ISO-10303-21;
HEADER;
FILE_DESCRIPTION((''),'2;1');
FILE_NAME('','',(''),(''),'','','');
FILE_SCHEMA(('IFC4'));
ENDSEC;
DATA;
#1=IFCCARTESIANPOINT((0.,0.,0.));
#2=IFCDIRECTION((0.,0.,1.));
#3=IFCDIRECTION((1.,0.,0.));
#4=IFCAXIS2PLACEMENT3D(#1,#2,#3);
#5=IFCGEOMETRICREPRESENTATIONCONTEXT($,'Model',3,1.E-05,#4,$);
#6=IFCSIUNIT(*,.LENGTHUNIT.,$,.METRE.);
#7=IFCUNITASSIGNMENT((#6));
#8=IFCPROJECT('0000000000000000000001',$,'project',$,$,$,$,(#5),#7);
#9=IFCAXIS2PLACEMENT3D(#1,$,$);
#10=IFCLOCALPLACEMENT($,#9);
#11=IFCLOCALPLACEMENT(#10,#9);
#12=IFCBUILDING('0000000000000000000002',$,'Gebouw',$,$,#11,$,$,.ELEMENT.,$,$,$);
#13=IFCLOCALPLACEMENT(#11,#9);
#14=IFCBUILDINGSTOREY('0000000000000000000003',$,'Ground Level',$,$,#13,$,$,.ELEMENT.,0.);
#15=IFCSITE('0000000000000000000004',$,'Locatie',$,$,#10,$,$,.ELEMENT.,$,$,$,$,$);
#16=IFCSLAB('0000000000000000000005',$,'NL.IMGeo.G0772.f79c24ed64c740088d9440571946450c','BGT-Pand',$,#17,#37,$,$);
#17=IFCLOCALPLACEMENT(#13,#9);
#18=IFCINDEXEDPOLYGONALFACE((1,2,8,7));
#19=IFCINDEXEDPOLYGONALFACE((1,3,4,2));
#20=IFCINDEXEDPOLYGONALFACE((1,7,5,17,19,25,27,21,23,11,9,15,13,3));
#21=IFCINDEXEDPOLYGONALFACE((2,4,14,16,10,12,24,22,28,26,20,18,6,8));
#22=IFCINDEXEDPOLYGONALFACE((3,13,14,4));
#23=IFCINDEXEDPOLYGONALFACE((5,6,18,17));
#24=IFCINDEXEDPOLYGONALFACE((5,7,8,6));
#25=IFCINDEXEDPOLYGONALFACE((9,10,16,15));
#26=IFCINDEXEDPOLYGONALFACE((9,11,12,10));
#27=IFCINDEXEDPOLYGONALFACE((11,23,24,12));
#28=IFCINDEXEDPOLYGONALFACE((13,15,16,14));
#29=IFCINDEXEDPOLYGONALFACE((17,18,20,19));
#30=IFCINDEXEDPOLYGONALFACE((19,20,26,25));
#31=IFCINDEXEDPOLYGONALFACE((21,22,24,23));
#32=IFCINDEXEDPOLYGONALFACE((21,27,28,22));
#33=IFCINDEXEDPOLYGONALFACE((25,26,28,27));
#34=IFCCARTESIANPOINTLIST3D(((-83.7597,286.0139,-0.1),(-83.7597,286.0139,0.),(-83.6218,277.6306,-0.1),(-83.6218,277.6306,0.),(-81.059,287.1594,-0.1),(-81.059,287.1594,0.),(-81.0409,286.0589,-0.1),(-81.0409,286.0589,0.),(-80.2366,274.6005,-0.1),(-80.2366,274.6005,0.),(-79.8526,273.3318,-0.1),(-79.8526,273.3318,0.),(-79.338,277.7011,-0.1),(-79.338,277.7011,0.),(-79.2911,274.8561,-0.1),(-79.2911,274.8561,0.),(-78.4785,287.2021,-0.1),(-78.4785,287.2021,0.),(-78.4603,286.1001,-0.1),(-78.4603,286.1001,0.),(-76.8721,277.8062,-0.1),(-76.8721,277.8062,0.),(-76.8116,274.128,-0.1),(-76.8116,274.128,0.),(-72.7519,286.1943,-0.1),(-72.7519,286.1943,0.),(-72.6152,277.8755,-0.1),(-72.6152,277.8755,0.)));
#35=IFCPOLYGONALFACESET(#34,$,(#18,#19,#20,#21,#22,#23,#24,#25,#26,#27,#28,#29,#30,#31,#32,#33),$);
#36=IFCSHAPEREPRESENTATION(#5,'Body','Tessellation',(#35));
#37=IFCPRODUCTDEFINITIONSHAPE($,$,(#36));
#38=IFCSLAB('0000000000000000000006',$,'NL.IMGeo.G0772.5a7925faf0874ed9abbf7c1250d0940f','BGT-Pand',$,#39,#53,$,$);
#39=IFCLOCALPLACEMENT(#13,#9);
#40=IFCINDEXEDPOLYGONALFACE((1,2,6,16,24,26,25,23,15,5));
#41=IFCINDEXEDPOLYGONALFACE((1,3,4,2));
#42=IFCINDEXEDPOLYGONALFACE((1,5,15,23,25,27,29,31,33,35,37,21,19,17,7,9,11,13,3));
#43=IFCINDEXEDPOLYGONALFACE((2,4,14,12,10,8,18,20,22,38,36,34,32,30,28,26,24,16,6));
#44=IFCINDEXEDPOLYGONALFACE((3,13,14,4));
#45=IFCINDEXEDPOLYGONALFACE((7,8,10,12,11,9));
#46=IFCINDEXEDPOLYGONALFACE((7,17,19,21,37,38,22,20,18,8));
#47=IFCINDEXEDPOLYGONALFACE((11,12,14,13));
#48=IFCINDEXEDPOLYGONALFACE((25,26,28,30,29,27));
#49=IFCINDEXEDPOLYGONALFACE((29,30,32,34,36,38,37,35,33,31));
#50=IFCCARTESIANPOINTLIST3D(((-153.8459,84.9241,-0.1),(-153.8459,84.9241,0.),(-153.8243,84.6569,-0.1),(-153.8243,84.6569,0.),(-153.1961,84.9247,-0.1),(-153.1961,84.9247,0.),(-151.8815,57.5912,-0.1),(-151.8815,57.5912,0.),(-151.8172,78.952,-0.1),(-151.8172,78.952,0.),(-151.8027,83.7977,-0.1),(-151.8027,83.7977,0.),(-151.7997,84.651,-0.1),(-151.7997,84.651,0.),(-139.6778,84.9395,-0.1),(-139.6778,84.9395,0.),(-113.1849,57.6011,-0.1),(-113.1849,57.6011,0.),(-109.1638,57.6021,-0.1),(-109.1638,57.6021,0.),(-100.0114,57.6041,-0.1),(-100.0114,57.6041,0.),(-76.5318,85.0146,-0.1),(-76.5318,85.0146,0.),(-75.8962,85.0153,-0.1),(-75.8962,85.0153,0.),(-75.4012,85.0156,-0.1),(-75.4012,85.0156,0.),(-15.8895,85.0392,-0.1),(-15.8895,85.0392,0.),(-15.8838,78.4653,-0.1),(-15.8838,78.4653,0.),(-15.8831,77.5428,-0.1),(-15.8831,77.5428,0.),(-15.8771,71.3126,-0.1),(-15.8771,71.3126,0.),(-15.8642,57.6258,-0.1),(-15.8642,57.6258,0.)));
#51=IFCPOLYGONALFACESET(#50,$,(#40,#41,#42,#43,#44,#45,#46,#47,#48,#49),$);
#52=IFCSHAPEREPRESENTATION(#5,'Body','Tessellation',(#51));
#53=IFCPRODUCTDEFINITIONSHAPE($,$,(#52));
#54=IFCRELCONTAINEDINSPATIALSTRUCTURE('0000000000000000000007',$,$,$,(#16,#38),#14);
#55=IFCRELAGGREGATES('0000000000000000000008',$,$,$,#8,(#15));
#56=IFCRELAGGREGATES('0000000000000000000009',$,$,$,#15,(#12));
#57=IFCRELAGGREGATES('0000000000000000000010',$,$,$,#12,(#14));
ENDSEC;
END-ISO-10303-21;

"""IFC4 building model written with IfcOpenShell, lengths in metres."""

from ifc_helpers import new_model, si_unit, frame, origin, origin_with_axes, place, context, project, spatial, polyline, outline, extrude, element, save


model = new_model("IFC4")

# Units and contexts
model_context = context("Model", 3, precision=1e-05, world=origin_with_axes())
ifc_project = project(units=[si_unit("LENGTHUNIT", "METRE")], contexts=[model_context])

# Site, building, storey
site_placement = place(None, origin())
site = spatial("IfcSite", under=ifc_project, at=site_placement, Name="Locatie", CompositionType="ELEMENT")
building_placement = place(site_placement, origin())
building = spatial("IfcBuilding", under=site, at=building_placement, Name="Gebouw", CompositionType="ELEMENT")
storey_placement = place(building_placement, origin())
storey = spatial("IfcBuildingStorey", under=building, at=storey_placement, Name="Ground Level", CompositionType="ELEMENT", Elevation=0.0)

# Slabs
slab_1_placement = place(storey_placement, origin())
element("IfcSlab", 1, at=slab_1_placement, inside=storey, Name="NL.IMGeo.G0772.f79c24ed64c740088d9440571946450c", Description="BGT-Pand", context=model_context, shape_type="SweptSolid", body=[
    extrude(outline(polyline([(-72.6152, 277.8755), (-76.8721, 277.8062), (-76.8116, 274.128), (-79.8526, 273.3318), (-80.2366, 274.6005), (-79.2911, 274.8561), (-79.338, 277.7011), (-83.6218, 277.6306), (-83.7597, 286.0139), (-81.0409, 286.0589), (-81.059, 287.1594), (-78.4785, 287.2021), (-78.4603, 286.1001), (-72.7519, 286.1943), (-72.6152, 277.8755)])), frame((0.0, 0.0, -0.1), z_axis=(0.0, 0.0, 1.0), x_axis=(1.0, 0.0, 0.0)), (0.0, 0.0, 1.0), 0.1),
])
slab_2_placement = place(storey_placement, origin())
element("IfcSlab", 2, at=slab_2_placement, inside=storey, Name="NL.IMGeo.G0772.5a7925faf0874ed9abbf7c1250d0940f", Description="BGT-Pand", context=model_context, shape_type="SweptSolid", body=[
    extrude(outline(polyline([(-76.5318, 85.0146), (-75.8962, 85.0153), (-75.4012, 85.0156), (-15.8895, 85.0392), (-15.8838, 78.4653), (-15.8831, 77.5428), (-15.8771, 71.3126), (-15.8642, 57.6258), (-100.0114, 57.6041), (-109.1638, 57.6021), (-113.1849, 57.6011), (-151.8815, 57.5912), (-151.8172, 78.952), (-151.8027, 83.7977), (-151.7997, 84.651), (-153.8243, 84.6569), (-153.8459, 84.9241), (-153.1961, 84.9247), (-139.6778, 84.9395), (-76.5318, 85.0146)])), frame((0.0, 0.0, -0.1), z_axis=(0.0, 0.0, 1.0), x_axis=(1.0, 0.0, 0.0)), (0.0, 0.0, 1.0), 0.1),
])

save(model, "model.ifc")
